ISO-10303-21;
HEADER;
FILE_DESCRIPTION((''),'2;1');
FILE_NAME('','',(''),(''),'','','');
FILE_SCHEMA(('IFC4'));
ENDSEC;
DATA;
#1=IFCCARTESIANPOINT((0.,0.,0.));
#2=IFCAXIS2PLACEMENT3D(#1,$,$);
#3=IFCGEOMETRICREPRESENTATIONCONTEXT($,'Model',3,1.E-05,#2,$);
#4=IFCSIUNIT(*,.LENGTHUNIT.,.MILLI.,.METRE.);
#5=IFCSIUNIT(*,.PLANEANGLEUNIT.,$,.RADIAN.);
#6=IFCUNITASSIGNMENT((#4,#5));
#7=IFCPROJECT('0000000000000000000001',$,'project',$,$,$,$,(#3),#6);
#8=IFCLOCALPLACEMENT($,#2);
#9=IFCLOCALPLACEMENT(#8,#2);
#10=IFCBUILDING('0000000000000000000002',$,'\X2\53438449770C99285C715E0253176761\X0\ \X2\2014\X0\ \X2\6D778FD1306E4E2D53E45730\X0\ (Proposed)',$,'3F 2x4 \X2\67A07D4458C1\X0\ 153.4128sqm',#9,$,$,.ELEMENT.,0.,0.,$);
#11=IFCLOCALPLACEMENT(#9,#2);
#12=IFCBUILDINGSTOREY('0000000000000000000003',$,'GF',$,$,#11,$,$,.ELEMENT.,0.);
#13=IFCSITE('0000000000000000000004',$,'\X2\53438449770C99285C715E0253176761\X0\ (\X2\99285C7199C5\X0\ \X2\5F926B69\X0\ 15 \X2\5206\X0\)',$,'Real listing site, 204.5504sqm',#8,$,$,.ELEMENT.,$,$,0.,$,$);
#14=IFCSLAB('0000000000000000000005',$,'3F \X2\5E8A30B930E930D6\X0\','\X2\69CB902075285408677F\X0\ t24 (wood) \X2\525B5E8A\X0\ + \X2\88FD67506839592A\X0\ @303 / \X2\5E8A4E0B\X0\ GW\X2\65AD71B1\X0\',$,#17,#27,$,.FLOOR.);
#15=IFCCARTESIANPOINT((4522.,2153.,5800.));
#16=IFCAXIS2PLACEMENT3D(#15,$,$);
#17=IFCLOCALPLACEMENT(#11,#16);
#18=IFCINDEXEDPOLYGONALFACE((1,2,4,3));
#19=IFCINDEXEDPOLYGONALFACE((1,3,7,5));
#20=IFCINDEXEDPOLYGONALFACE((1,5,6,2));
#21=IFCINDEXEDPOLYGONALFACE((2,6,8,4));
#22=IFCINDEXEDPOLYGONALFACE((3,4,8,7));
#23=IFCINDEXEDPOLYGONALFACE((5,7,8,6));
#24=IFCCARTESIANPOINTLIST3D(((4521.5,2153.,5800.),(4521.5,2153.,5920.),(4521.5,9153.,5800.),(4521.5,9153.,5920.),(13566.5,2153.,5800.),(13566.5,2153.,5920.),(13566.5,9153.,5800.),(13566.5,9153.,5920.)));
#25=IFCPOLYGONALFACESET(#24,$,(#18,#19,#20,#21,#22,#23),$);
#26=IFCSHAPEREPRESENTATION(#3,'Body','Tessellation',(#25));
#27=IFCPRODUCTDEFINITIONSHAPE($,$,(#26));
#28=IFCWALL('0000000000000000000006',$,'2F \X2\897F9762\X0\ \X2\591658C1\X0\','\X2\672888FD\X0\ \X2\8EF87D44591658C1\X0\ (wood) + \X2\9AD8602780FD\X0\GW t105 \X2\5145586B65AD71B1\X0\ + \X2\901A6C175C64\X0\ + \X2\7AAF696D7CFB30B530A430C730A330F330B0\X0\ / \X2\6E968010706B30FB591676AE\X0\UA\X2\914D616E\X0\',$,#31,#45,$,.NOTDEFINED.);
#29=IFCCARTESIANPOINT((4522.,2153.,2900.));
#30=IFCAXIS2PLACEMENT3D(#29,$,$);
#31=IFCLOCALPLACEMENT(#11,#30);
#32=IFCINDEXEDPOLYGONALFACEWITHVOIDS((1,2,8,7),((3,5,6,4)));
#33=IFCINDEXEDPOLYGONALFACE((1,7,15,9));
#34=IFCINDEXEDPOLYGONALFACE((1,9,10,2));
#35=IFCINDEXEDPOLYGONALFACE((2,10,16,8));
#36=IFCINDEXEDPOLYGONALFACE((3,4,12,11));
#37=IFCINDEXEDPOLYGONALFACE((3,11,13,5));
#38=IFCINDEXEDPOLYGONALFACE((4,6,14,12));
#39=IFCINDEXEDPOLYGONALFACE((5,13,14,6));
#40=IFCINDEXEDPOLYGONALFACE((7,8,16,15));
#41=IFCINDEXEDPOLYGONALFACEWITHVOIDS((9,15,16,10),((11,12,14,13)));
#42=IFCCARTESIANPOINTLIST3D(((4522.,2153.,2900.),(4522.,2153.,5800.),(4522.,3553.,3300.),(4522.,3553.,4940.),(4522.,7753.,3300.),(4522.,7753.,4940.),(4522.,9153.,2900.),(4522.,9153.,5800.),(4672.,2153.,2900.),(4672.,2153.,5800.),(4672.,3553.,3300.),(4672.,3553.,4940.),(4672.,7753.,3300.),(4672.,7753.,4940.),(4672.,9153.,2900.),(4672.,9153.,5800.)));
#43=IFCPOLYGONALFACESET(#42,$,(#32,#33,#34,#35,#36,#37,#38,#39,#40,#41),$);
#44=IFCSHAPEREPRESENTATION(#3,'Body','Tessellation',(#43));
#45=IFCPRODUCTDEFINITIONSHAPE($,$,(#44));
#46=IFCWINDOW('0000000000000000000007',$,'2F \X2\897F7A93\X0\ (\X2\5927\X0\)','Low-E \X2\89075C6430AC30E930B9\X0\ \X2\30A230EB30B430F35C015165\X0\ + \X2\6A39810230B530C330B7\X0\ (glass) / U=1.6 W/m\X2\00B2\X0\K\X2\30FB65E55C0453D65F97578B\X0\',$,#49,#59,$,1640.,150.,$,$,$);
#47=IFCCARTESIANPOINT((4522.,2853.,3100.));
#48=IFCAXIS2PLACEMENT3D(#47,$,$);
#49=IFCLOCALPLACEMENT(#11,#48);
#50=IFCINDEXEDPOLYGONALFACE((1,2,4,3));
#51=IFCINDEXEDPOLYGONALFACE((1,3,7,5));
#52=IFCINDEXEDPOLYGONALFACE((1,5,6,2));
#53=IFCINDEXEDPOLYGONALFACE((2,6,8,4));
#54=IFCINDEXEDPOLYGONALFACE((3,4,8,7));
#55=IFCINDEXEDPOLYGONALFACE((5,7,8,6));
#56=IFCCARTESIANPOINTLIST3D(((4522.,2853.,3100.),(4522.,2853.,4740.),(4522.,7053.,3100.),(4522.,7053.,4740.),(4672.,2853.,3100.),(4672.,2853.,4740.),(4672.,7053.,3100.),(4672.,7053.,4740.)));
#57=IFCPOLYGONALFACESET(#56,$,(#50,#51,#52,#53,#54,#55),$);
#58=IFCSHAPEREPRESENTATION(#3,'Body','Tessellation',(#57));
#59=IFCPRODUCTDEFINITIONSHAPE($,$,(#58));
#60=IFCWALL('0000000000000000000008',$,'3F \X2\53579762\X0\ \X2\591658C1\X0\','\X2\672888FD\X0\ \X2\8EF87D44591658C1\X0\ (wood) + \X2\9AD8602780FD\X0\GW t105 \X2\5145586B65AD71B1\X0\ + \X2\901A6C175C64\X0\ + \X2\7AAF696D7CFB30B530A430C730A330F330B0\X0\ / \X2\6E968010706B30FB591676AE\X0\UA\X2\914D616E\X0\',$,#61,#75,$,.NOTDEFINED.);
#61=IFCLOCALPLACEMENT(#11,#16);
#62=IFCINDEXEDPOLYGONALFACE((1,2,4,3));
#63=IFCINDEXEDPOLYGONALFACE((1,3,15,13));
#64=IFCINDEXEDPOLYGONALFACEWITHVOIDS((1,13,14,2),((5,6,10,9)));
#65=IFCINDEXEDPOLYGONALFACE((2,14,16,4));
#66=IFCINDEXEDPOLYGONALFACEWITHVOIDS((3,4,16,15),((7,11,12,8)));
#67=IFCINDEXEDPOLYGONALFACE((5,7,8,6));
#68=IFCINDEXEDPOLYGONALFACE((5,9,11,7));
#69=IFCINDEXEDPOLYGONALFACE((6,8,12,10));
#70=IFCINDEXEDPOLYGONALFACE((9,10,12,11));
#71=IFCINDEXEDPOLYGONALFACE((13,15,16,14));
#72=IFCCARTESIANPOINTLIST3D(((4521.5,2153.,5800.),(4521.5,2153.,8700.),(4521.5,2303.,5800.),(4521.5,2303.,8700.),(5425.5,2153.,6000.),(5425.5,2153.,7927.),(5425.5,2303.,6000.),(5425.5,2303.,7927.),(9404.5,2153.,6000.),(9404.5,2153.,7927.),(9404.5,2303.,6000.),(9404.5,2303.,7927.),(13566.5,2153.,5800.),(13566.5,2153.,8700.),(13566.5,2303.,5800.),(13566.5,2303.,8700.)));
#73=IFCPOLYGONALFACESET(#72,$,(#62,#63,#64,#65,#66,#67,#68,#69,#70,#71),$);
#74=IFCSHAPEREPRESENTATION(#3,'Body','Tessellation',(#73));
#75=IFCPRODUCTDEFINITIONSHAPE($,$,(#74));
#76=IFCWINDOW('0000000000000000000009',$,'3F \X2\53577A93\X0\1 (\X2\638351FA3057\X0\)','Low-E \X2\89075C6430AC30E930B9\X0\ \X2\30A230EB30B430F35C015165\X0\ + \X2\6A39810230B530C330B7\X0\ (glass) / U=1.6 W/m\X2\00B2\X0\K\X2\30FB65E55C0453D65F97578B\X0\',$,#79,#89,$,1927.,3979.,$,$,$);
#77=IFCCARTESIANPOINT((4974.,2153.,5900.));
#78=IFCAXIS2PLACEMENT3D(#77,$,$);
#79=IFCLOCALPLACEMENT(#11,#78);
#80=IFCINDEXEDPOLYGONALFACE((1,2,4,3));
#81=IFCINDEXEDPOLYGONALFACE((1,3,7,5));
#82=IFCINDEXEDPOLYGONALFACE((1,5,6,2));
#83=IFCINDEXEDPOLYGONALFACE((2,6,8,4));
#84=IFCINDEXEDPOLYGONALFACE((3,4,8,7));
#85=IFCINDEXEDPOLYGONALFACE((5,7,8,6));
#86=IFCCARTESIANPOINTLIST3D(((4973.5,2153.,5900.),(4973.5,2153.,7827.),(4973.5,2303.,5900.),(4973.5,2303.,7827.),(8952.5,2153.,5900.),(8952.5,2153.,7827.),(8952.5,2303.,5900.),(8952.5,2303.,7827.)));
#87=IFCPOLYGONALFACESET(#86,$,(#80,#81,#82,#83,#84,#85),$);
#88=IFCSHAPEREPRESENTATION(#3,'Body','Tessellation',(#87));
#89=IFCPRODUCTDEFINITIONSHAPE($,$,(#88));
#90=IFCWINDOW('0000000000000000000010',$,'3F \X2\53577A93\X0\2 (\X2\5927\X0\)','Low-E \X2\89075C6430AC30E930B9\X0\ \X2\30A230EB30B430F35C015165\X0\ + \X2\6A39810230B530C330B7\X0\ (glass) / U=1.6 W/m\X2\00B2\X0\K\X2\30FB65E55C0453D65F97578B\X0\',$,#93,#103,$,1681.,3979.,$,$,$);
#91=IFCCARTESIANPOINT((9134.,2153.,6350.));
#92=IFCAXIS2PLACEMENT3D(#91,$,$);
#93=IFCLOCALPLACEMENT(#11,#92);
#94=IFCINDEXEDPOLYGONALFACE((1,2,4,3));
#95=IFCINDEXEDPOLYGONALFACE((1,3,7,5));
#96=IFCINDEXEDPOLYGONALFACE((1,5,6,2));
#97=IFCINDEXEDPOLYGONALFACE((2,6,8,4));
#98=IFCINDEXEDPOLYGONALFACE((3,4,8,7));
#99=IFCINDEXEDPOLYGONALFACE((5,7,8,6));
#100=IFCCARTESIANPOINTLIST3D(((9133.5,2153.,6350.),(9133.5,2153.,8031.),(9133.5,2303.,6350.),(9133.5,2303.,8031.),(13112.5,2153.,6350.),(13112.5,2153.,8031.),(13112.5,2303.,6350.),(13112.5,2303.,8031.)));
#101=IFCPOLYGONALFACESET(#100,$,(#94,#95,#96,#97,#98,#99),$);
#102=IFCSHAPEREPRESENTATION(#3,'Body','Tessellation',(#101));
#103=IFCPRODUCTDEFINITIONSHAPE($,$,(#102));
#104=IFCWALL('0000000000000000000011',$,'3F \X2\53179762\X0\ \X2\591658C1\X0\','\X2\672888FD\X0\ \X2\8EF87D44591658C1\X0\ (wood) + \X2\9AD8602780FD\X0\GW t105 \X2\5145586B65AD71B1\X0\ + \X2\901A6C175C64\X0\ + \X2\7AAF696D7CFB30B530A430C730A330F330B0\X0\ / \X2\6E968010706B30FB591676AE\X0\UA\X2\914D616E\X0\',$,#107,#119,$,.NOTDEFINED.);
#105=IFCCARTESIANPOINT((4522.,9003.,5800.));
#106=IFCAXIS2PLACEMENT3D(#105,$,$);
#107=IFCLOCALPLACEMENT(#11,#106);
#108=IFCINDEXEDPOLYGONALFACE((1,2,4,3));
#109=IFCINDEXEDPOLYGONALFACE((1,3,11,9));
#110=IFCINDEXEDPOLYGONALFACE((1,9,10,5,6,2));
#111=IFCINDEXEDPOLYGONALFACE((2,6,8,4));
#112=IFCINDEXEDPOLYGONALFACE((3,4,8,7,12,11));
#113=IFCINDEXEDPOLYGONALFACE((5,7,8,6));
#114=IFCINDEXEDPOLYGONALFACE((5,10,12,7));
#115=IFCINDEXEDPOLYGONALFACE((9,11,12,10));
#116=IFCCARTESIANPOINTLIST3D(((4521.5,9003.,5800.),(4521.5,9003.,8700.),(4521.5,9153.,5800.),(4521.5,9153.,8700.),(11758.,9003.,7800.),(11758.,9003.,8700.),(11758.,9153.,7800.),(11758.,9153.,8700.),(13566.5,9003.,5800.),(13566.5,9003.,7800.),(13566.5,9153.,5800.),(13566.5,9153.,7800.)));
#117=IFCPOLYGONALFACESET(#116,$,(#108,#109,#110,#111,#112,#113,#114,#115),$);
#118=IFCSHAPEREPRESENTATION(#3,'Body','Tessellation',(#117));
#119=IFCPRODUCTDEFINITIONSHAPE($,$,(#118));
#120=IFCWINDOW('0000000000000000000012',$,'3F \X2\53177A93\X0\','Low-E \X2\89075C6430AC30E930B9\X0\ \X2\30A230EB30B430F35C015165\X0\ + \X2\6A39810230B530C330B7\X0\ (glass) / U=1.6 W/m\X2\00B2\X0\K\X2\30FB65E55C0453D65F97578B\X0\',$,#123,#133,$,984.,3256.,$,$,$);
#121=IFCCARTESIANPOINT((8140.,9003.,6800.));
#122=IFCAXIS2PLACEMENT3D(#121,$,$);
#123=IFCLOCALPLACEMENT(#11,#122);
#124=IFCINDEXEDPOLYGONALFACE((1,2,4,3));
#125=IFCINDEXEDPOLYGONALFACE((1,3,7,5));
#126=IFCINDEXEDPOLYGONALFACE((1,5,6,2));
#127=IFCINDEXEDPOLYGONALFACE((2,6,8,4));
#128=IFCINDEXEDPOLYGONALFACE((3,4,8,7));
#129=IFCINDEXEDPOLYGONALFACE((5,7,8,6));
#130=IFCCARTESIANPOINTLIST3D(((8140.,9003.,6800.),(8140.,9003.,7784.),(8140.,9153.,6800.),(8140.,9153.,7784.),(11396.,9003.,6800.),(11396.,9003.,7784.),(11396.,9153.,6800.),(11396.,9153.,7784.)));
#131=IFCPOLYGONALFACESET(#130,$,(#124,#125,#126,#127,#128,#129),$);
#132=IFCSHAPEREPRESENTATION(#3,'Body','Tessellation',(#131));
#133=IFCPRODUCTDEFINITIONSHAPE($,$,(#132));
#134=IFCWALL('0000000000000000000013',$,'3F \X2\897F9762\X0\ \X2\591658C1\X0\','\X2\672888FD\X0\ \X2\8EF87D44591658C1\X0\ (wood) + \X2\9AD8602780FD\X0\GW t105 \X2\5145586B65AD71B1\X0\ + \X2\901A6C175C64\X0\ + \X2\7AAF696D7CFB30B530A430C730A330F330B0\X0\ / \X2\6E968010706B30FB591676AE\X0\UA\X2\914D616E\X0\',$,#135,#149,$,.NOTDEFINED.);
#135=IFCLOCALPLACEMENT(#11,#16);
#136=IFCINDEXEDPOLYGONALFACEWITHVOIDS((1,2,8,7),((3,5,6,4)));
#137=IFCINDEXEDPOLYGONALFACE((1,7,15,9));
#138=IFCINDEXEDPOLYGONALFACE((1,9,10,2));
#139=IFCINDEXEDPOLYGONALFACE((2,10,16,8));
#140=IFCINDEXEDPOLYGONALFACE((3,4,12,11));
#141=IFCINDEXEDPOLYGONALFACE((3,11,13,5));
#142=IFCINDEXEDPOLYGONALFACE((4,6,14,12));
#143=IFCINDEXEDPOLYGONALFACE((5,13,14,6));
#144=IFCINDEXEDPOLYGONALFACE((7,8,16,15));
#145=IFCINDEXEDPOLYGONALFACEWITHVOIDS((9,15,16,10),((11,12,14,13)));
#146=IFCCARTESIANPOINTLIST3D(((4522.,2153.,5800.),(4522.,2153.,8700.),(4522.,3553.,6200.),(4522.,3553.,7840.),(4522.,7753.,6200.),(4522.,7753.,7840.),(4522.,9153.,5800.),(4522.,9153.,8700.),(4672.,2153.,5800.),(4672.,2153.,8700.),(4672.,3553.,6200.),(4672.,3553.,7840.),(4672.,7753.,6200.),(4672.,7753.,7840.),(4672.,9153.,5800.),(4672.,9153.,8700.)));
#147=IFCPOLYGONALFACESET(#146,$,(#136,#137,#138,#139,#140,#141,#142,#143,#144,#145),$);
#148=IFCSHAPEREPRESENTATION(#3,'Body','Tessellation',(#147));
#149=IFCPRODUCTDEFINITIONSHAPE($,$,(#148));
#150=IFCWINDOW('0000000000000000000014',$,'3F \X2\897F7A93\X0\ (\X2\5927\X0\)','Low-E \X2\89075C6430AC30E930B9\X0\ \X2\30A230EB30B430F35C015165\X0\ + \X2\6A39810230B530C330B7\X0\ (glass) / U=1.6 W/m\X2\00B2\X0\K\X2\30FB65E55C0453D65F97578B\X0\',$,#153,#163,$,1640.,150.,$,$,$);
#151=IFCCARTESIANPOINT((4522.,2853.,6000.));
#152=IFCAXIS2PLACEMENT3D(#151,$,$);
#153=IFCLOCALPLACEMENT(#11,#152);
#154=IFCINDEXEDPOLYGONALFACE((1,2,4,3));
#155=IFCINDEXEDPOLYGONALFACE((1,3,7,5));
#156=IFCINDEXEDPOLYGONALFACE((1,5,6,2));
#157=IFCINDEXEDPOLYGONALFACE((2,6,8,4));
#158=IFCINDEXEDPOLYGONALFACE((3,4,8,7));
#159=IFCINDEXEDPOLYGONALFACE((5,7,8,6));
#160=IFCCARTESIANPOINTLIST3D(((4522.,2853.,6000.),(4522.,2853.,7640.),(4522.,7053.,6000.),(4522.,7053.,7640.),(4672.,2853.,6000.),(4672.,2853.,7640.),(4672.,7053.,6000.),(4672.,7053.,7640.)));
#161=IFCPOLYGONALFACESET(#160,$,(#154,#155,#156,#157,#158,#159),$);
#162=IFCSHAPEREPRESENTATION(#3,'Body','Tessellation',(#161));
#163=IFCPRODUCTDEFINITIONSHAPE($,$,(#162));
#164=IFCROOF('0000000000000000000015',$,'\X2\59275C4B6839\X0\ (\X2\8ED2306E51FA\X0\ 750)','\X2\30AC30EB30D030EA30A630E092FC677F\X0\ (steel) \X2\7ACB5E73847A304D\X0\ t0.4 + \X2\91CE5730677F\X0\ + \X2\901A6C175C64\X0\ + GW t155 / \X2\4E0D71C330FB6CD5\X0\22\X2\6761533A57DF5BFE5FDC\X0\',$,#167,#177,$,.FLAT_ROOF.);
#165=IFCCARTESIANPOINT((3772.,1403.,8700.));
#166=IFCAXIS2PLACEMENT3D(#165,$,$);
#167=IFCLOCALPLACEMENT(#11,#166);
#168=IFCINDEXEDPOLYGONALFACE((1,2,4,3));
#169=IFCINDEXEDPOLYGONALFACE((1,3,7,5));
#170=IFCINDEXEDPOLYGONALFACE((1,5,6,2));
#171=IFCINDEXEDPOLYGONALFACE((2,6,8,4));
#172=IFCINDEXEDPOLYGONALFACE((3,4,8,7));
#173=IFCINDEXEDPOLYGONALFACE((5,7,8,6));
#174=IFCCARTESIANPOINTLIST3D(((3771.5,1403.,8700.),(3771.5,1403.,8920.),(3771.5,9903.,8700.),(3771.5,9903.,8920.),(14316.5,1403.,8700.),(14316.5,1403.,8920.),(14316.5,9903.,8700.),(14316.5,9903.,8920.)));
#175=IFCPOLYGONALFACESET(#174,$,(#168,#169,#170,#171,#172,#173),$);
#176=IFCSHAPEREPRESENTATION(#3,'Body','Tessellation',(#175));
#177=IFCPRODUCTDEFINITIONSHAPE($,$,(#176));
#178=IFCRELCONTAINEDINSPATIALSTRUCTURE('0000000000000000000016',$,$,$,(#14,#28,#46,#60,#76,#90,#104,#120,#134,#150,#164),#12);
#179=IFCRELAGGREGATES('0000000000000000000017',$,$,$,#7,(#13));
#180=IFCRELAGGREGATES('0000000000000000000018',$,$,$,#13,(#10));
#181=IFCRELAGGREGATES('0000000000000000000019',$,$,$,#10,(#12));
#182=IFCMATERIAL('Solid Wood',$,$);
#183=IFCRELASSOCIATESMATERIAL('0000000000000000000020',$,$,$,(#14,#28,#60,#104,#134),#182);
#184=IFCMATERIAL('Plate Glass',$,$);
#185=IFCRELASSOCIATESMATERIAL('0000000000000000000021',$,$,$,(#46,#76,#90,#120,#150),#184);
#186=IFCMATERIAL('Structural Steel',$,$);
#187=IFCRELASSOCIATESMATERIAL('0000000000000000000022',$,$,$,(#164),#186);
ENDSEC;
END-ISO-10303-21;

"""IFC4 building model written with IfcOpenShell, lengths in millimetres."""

from ifc_helpers import new_model, si_unit, frame, frame_2d, origin, place, context, project, spatial, rectangle, extrude, material, element, fill, save


model = new_model("IFC4")

# Units and contexts
model_context = context("Model", 3, precision=1e-05, world=origin())
ifc_project = project(units=[si_unit("LENGTHUNIT", "METRE", prefix="MILLI"), si_unit("PLANEANGLEUNIT", "RADIAN")], contexts=[model_context])

# Site, building, storey
site_placement = place(None, origin())
site = spatial("IfcSite", under=ifc_project, at=site_placement, Name="千葉県館山市北条 (館山駅 徒歩 15 分)", ObjectType="Real listing site, 204.5504sqm", CompositionType="ELEMENT", RefElevation=0.0)
building_placement = place(site_placement, origin())
building = spatial("IfcBuilding", under=site, at=building_placement, Name="千葉県館山市北条 — 海近の中古地 (Proposed)", ObjectType="3F 2x4 枠組壁 153.4128sqm", CompositionType="ELEMENT", ElevationOfRefHeight=0.0, ElevationOfTerrain=0.0)
storey_placement = place(building_placement, origin())
storey = spatial("IfcBuildingStorey", under=building, at=storey_placement, Name="GF", CompositionType="ELEMENT", Elevation=0.0)

# Slab
ifc_material_1 = material(Name="Solid Wood")
slab_placement = place(storey_placement, frame((4522.0, 2153.0, 5800.0)))
element("IfcSlab", 1, at=slab_placement, inside=storey, material=ifc_material_1, Name="3F 床スラブ", Description="構造用合板 t24 (wood) 剛床 + 製材根太 @303 / 床下 GW断熱", PredefinedType="FLOOR", context=model_context, shape_type="SweptSolid", body=[
    extrude(rectangle(XDim=9045.0, YDim=7000.0, at=frame_2d((4522.0, 3500.0))), frame((4522.0, 2153.0, 5800.0)), (0.0, 0.0, 1.0), 120.0),
])

# Wall, opening, window
wall_1_placement = place(storey_placement, frame((4522.0, 2153.0, 2900.0)))
wall_1 = element("IfcWall", 2, at=wall_1_placement, inside=storey, material=ifc_material_1, Name="2F 西面 外壁", Description="木製 軸組外壁 (wood) + 高性能GW t105 充填断熱 + 通気層 + 窯業系サイディング / 準耐火・外皮UA配慮", PredefinedType="NOTDEFINED", context=model_context, shape_type="SweptSolid", body=[
    extrude(rectangle(XDim=150.0, YDim=7000.0, at=frame_2d((75.0, 3500.0))), frame((4522.0, 2153.0, 2900.0)), (0.0, 0.0, 1.0), 2900.0),
])
opening_1_placement = place(storey_placement, frame((4522.0, 2853.0, 3100.0)))
opening_1 = element("IfcOpeningElement", 3, at=opening_1_placement, cuts=wall_1, PredefinedType="NOTDEFINED", context=model_context, shape_type="SweptSolid", body=[
    extrude(rectangle(XDim=150.0, YDim=4200.0, at=frame_2d((75.0, 2100.0))), frame((4522.0, 2853.0, 3100.0)), (0.0, 0.0, 1.0), 1640.0),
])
ifc_material_2 = material(Name="Plate Glass")
window_1_placement = place(storey_placement, frame((4522.0, 2853.0, 3100.0)))
window_1 = element("IfcWindow", 4, at=window_1_placement, inside=storey, material=ifc_material_2, Name="2F 西窓 (大)", Description="Low-E 複層ガラス アルゴン封入 + 樹脂サッシ (glass) / U=1.6 W/m²K・日射取得型", OverallHeight=1640.0, OverallWidth=150.0, context=model_context, shape_type="SweptSolid", body=[
    extrude(rectangle(XDim=150.0, YDim=4200.0, at=frame_2d((75.0, 2100.0))), frame((4522.0, 2853.0, 3100.0)), (0.0, 0.0, 1.0), 1640.0),
])
fill(opening_1, window_1)

# Wall, openings, windows
wall_2_placement = place(storey_placement, frame((4522.0, 2153.0, 5800.0)))
wall_2 = element("IfcWall", 5, at=wall_2_placement, inside=storey, material=ifc_material_1, Name="3F 南面 外壁", Description="木製 軸組外壁 (wood) + 高性能GW t105 充填断熱 + 通気層 + 窯業系サイディング / 準耐火・外皮UA配慮", PredefinedType="NOTDEFINED", context=model_context, shape_type="SweptSolid", body=[
    extrude(rectangle(XDim=9045.0, YDim=150.0, at=frame_2d((4522.0, 75.0))), frame((4522.0, 2153.0, 5800.0)), (0.0, 0.0, 1.0), 2900.0),
])
opening_2_placement = place(storey_placement, frame((4974.0, 2153.0, 5900.0)))
opening_2 = element("IfcOpeningElement", 6, at=opening_2_placement, cuts=wall_2, PredefinedType="NOTDEFINED", context=model_context, shape_type="SweptSolid", body=[
    extrude(rectangle(XDim=3979.0, YDim=150.0, at=frame_2d((1989.0, 75.0))), frame((4974.0, 2153.0, 5900.0)), (0.0, 0.0, 1.0), 1927.0),
])
opening_3_placement = place(storey_placement, frame((9134.0, 2153.0, 6350.0)))
opening_3 = element("IfcOpeningElement", 7, at=opening_3_placement, cuts=wall_2, PredefinedType="NOTDEFINED", context=model_context, shape_type="SweptSolid", body=[
    extrude(rectangle(XDim=3979.0, YDim=150.0, at=frame_2d((1989.0, 75.0))), frame((9134.0, 2153.0, 6350.0)), (0.0, 0.0, 1.0), 1681.0),
])
window_2_placement = place(storey_placement, frame((4974.0, 2153.0, 5900.0)))
window_2 = element("IfcWindow", 8, at=window_2_placement, inside=storey, material=ifc_material_2, Name="3F 南窓1 (掃出し)", Description="Low-E 複層ガラス アルゴン封入 + 樹脂サッシ (glass) / U=1.6 W/m²K・日射取得型", OverallHeight=1927.0, OverallWidth=3979.0, context=model_context, shape_type="SweptSolid", body=[
    extrude(rectangle(XDim=3979.0, YDim=150.0, at=frame_2d((1989.0, 75.0))), frame((4974.0, 2153.0, 5900.0)), (0.0, 0.0, 1.0), 1927.0),
])
fill(opening_2, window_2)
window_3_placement = place(storey_placement, frame((9134.0, 2153.0, 6350.0)))
window_3 = element("IfcWindow", 9, at=window_3_placement, inside=storey, material=ifc_material_2, Name="3F 南窓2 (大)", Description="Low-E 複層ガラス アルゴン封入 + 樹脂サッシ (glass) / U=1.6 W/m²K・日射取得型", OverallHeight=1681.0, OverallWidth=3979.0, context=model_context, shape_type="SweptSolid", body=[
    extrude(rectangle(XDim=3979.0, YDim=150.0, at=frame_2d((1989.0, 75.0))), frame((9134.0, 2153.0, 6350.0)), (0.0, 0.0, 1.0), 1681.0),
])
fill(opening_3, window_3)

# Walls, openings, windows
wall_3_placement = place(storey_placement, frame((4522.0, 9003.0, 5800.0)))
wall_3 = element("IfcWall", 10, at=wall_3_placement, inside=storey, material=ifc_material_1, Name="3F 北面 外壁", Description="木製 軸組外壁 (wood) + 高性能GW t105 充填断熱 + 通気層 + 窯業系サイディング / 準耐火・外皮UA配慮", PredefinedType="NOTDEFINED", context=model_context, shape_type="SweptSolid", body=[
    extrude(rectangle(XDim=9045.0, YDim=150.0, at=frame_2d((4522.0, 75.0))), frame((4522.0, 9003.0, 5800.0)), (0.0, 0.0, 1.0), 2900.0),
])
opening_4_placement = place(storey_placement, frame((8140.0, 9003.0, 6800.0)))
opening_4 = element("IfcOpeningElement", 11, at=opening_4_placement, cuts=wall_3, PredefinedType="NOTDEFINED", context=model_context, shape_type="SweptSolid", body=[
    extrude(rectangle(XDim=3256.0, YDim=150.0, at=frame_2d((1628.0, 75.0))), frame((8140.0, 9003.0, 6800.0)), (0.0, 0.0, 1.0), 984.0),
])
window_4_placement = place(storey_placement, frame((8140.0, 9003.0, 6800.0)))
window_4 = element("IfcWindow", 12, at=window_4_placement, inside=storey, material=ifc_material_2, Name="3F 北窓", Description="Low-E 複層ガラス アルゴン封入 + 樹脂サッシ (glass) / U=1.6 W/m²K・日射取得型", OverallHeight=984.0, OverallWidth=3256.0, context=model_context, shape_type="SweptSolid", body=[
    extrude(rectangle(XDim=3256.0, YDim=150.0, at=frame_2d((1628.0, 75.0))), frame((8140.0, 9003.0, 6800.0)), (0.0, 0.0, 1.0), 984.0),
])
fill(opening_4, window_4)
wall_4_placement = place(storey_placement, frame((4522.0, 2153.0, 5800.0)))
wall_4 = element("IfcWall", 13, at=wall_4_placement, inside=storey, material=ifc_material_1, Name="3F 西面 外壁", Description="木製 軸組外壁 (wood) + 高性能GW t105 充填断熱 + 通気層 + 窯業系サイディング / 準耐火・外皮UA配慮", PredefinedType="NOTDEFINED", context=model_context, shape_type="SweptSolid", body=[
    extrude(rectangle(XDim=150.0, YDim=7000.0, at=frame_2d((75.0, 3500.0))), frame((4522.0, 2153.0, 5800.0)), (0.0, 0.0, 1.0), 2900.0),
])
opening_5_placement = place(storey_placement, frame((4522.0, 2853.0, 6000.0)))
opening_5 = element("IfcOpeningElement", 14, at=opening_5_placement, cuts=wall_4, PredefinedType="NOTDEFINED", context=model_context, shape_type="SweptSolid", body=[
    extrude(rectangle(XDim=150.0, YDim=4200.0, at=frame_2d((75.0, 2100.0))), frame((4522.0, 2853.0, 6000.0)), (0.0, 0.0, 1.0), 1640.0),
])
window_5_placement = place(storey_placement, frame((4522.0, 2853.0, 6000.0)))
window_5 = element("IfcWindow", 15, at=window_5_placement, inside=storey, material=ifc_material_2, Name="3F 西窓 (大)", Description="Low-E 複層ガラス アルゴン封入 + 樹脂サッシ (glass) / U=1.6 W/m²K・日射取得型", OverallHeight=1640.0, OverallWidth=150.0, context=model_context, shape_type="SweptSolid", body=[
    extrude(rectangle(XDim=150.0, YDim=4200.0, at=frame_2d((75.0, 2100.0))), frame((4522.0, 2853.0, 6000.0)), (0.0, 0.0, 1.0), 1640.0),
])
fill(opening_5, window_5)

# Roof
ifc_material_3 = material(Name="Structural Steel")
roof_1_placement = place(storey_placement, frame((3772.0, 1403.0, 8700.0)))
element("IfcRoof", 16, at=roof_1_placement, inside=storey, material=ifc_material_3, Name="大屋根 (軒の出 750)", Description="ガルバリウム鋼板 (steel) 立平葺き t0.4 + 野地板 + 通気層 + GW t155 / 不燃・法22条区域対応", PredefinedType="FLAT_ROOF", context=model_context, shape_type="SweptSolid", body=[
    extrude(rectangle(XDim=10545.0, YDim=8500.0, at=frame_2d((5272.0, 4250.0))), frame((3772.0, 1403.0, 8700.0)), (0.0, 0.0, 1.0), 220.0),
])

save(model, "model.ifc")
